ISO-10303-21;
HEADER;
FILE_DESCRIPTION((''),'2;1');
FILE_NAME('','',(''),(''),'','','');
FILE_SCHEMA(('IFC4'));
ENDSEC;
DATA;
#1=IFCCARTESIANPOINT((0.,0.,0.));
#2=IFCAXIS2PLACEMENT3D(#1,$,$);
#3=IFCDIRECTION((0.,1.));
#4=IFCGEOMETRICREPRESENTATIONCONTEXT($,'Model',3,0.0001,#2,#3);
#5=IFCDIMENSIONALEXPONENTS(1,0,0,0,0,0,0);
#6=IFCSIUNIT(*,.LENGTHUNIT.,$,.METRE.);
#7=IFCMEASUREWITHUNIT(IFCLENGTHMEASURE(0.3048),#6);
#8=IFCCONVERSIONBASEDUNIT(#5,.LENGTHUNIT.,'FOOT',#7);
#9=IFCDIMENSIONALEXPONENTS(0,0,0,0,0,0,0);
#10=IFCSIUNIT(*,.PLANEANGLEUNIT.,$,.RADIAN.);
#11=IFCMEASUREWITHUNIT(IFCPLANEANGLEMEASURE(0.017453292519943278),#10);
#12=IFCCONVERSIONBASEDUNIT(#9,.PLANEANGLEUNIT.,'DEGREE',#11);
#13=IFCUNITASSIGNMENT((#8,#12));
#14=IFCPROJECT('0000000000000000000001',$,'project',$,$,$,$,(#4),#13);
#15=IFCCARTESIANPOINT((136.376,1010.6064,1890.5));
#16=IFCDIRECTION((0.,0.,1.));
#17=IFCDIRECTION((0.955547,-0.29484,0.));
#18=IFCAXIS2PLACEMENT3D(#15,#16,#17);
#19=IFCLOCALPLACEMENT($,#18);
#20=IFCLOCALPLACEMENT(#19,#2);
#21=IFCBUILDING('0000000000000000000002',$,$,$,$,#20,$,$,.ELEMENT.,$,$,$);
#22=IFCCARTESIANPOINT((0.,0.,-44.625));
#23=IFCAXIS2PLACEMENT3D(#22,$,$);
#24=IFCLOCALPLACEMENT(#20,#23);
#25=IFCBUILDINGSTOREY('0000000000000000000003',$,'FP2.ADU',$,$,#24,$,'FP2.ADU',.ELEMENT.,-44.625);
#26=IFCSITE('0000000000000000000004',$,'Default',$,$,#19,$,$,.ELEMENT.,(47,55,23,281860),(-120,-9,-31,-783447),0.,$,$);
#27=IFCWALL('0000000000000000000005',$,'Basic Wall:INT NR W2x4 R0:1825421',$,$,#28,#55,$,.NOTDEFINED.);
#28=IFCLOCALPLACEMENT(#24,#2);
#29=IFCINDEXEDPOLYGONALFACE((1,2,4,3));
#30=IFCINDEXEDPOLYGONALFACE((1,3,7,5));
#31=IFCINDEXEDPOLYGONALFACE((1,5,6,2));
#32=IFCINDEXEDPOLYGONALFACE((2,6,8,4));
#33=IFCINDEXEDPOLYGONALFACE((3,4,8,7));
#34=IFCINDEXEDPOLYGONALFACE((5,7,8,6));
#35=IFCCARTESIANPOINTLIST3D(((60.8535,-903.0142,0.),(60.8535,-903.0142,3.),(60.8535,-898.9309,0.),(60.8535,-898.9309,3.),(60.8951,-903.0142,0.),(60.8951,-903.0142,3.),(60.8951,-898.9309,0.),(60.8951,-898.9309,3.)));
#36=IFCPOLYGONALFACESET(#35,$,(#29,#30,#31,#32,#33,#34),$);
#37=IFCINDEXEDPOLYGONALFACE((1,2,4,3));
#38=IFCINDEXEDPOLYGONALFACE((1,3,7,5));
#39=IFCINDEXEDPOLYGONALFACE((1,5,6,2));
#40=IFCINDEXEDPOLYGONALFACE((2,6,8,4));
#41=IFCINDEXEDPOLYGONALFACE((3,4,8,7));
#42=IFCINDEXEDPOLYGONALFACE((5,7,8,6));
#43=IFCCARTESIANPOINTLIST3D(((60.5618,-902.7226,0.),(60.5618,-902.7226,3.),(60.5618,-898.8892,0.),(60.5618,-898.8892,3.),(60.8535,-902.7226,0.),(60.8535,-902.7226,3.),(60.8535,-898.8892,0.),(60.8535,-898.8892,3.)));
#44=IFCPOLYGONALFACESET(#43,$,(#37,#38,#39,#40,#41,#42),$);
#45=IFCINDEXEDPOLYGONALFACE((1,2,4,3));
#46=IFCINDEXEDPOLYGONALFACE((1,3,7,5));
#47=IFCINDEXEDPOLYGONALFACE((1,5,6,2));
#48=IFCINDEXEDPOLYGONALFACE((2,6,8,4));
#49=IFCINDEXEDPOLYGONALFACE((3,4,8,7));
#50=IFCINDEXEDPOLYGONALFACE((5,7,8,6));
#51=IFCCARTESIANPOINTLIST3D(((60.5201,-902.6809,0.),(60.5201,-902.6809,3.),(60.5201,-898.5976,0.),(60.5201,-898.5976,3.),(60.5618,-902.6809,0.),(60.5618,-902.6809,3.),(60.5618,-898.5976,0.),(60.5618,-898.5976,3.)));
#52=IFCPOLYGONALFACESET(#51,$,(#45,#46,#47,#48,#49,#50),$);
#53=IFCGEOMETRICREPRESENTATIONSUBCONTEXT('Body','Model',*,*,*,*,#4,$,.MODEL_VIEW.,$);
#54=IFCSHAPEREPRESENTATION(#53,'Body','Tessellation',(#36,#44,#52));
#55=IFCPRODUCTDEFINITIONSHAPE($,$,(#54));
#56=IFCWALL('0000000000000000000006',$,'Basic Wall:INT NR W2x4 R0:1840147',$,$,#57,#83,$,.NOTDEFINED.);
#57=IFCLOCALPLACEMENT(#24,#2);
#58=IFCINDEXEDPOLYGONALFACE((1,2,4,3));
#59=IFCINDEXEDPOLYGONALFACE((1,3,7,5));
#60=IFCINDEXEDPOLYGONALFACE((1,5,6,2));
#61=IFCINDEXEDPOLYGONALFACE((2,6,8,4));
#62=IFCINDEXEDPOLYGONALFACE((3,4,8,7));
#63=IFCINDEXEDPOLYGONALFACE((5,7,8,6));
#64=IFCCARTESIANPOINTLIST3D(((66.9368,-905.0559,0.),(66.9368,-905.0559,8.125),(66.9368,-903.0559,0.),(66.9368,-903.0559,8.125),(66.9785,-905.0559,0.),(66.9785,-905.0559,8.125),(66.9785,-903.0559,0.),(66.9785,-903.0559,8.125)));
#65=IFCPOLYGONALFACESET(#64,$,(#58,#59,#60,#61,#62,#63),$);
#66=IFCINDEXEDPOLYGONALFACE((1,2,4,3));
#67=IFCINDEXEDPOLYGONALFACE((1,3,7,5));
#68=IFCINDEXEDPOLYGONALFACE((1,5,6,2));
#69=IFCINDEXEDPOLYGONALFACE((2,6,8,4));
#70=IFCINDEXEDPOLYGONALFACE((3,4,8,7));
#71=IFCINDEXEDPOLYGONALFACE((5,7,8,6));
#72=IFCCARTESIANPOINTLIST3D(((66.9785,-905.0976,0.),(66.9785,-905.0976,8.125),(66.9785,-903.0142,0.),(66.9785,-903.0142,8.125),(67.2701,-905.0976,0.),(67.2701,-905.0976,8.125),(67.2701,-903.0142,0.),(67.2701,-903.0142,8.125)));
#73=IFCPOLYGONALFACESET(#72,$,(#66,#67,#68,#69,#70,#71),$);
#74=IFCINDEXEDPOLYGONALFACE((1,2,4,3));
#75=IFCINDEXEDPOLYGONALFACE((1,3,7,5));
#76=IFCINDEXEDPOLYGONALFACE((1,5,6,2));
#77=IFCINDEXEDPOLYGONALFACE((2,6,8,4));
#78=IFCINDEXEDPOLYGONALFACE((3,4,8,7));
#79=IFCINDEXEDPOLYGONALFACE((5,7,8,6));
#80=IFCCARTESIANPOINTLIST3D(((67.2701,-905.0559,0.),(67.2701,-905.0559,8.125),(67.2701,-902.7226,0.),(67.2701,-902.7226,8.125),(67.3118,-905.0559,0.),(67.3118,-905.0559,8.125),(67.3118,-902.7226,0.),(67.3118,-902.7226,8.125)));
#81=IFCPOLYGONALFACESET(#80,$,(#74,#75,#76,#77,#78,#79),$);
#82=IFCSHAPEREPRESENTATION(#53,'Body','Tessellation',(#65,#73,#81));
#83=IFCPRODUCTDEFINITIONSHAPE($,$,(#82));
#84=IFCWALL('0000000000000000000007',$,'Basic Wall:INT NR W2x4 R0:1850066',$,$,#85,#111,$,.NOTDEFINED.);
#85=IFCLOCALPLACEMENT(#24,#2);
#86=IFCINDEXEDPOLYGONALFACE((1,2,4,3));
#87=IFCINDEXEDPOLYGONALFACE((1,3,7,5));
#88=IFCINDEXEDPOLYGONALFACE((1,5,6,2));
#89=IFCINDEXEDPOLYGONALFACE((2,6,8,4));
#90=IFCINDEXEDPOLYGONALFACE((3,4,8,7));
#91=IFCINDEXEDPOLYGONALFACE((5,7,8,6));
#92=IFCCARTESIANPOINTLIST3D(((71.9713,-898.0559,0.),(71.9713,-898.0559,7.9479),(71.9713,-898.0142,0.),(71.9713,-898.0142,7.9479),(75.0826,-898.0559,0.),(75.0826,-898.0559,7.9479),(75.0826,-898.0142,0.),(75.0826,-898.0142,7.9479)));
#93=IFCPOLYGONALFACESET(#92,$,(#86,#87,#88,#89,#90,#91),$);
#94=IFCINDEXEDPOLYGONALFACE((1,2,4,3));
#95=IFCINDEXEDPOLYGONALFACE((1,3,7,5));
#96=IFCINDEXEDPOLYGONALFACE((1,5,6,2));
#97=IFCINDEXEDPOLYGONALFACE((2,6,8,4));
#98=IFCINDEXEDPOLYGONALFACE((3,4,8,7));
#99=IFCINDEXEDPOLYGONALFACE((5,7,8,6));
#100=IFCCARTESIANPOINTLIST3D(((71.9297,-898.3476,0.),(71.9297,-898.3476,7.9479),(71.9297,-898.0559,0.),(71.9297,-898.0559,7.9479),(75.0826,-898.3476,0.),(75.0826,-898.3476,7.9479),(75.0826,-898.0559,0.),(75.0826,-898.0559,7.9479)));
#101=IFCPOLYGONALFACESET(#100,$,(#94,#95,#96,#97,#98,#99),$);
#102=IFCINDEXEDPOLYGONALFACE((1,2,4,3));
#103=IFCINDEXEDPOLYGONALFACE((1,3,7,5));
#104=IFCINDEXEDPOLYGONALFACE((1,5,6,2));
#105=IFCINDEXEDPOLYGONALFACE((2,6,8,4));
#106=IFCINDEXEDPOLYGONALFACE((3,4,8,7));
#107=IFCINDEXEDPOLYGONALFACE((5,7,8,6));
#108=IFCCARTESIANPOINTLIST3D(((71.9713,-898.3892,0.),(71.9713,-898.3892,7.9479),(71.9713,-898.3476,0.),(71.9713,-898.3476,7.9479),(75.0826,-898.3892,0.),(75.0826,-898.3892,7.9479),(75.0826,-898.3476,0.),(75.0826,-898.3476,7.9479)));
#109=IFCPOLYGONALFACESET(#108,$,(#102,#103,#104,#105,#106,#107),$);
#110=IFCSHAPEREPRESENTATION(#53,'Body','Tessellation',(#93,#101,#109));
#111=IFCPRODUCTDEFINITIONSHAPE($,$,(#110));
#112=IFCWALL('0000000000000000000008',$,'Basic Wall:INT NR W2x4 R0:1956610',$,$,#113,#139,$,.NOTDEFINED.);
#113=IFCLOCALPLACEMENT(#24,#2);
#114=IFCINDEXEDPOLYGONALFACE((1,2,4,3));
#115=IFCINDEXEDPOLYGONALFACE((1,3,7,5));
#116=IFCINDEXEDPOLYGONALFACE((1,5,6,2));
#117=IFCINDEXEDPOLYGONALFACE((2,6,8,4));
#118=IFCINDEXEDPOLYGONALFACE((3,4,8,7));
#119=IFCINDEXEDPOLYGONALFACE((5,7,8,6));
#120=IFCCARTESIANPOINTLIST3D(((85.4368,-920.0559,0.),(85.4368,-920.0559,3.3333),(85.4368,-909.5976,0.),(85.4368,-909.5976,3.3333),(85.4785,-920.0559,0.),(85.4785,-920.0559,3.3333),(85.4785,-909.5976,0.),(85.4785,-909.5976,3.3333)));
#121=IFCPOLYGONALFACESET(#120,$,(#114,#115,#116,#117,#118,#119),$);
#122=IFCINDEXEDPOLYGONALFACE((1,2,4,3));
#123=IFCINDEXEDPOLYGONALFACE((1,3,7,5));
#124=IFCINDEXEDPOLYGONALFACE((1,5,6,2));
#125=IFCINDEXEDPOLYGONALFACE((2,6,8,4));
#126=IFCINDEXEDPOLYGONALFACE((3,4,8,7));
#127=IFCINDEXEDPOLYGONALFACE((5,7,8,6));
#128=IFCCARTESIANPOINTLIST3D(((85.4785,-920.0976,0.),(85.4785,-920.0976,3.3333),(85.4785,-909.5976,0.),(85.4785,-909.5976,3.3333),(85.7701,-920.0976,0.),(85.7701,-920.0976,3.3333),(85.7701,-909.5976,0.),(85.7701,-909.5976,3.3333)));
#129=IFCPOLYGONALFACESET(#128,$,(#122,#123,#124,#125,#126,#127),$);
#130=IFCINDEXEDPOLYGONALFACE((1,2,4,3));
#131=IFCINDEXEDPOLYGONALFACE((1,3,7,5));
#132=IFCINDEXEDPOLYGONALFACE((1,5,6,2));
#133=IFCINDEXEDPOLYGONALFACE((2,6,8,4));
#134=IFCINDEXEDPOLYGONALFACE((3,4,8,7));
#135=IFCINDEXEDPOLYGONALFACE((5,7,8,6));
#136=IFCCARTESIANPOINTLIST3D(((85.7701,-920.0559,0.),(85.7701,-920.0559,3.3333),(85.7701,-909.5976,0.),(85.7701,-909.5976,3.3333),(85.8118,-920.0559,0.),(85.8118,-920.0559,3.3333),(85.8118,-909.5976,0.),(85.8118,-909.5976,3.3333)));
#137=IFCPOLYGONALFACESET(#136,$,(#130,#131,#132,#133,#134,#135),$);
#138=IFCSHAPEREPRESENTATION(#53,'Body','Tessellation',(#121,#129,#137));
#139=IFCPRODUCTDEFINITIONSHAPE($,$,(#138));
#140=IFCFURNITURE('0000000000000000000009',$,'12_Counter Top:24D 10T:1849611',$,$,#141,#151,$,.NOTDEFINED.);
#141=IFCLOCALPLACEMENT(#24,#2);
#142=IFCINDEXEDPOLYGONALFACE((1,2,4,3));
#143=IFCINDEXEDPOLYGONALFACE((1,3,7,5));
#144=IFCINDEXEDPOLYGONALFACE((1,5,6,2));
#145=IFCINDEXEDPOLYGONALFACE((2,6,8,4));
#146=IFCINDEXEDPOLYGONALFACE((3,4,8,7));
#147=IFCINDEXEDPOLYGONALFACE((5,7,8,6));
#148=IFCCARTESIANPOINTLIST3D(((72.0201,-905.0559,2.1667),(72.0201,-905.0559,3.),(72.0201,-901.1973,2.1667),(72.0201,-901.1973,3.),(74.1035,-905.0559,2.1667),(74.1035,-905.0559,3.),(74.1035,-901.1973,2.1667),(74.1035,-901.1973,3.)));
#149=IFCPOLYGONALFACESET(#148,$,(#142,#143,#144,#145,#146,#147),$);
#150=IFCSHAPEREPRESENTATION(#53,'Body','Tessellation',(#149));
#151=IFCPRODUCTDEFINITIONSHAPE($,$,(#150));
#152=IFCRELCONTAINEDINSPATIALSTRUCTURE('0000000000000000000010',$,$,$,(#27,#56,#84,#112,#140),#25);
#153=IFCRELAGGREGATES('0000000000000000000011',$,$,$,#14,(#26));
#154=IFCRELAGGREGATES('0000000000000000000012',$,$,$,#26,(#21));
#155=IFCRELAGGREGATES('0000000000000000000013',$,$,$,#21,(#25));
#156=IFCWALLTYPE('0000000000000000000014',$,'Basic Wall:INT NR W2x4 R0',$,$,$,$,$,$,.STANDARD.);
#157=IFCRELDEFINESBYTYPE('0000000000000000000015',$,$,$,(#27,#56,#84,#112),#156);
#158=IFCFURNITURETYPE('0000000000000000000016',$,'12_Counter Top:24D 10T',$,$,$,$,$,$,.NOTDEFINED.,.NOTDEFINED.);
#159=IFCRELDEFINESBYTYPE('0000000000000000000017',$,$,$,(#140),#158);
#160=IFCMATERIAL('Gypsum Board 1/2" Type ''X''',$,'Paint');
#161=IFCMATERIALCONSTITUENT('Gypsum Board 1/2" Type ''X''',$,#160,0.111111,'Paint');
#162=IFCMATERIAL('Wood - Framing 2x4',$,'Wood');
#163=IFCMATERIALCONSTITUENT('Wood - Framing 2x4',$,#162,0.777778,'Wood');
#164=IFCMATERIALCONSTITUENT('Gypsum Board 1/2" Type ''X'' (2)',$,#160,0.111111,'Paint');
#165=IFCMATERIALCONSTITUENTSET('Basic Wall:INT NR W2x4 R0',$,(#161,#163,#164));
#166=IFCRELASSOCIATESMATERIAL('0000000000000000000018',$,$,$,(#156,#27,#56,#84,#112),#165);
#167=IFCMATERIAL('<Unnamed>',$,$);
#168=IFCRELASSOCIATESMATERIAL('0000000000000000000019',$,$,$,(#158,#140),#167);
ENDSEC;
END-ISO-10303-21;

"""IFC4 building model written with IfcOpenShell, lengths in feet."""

from ifc_helpers import new_model, entity, si_unit, converted_unit, direction, frame, origin, place, context, subcontext, project, spatial, indexed_curve, outline, extrude, source, transform, mapped, material, constituent, constituent_set, type_object, type_shapes, element, save


model = new_model("IFC4")

# Units and contexts
model_context = context("Model", 3, precision=0.0001, world=origin(), true_north=direction((0.0, 1.0)))
body_context = subcontext(model_context, "Body", "Model", "MODEL_VIEW")
ifc_project = project(units=[converted_unit("LENGTHUNIT", "FOOT", entity("IfcLengthMeasure", 0.3048), si_unit("LENGTHUNIT", "METRE"), dimensions=[1, 0, 0, 0, 0, 0, 0]), converted_unit("PLANEANGLEUNIT", "DEGREE", entity("IfcPlaneAngleMeasure", 0.017453292519943278), si_unit("PLANEANGLEUNIT", "RADIAN"), dimensions=[0, 0, 0, 0, 0, 0, 0])], contexts=[model_context])

# Site, building, storey
site_placement = place(None, frame((136.376, 1010.6064, 1890.5), z_axis=(0.0, 0.0, 1.0), x_axis=(0.955547, -0.29484, 0.0)))
site = spatial("IfcSite", under=ifc_project, at=site_placement, Name="Default", CompositionType="ELEMENT", RefLatitude=(47, 55, 23, 281860), RefLongitude=(-120, -9, -31, -783447), RefElevation=0.0)
building_placement = place(site_placement, origin())
building = spatial("IfcBuilding", under=site, at=building_placement, CompositionType="ELEMENT")
storey_placement = place(building_placement, frame((0.0, 0.0, -44.625)))
storey = spatial("IfcBuildingStorey", under=building, at=storey_placement, Name="FP2.ADU", LongName="FP2.ADU", CompositionType="ELEMENT", Elevation=-44.625)

# Shared definitions
ifc_material_1 = material(Name="Gypsum Board 1/2\" Type 'X'", Category="Paint")

# Shared definitions
ifc_constituent_1 = constituent(ifc_material_1, Name="Gypsum Board 1/2\" Type 'X'", Category="Paint", fraction=0.111111)
ifc_material_2 = material(Name="Wood - Framing 2x4", Category="Wood")
ifc_constituent_2 = constituent(ifc_material_2, Name="Wood - Framing 2x4", Category="Wood", fraction=0.777778)
ifc_constituent_3 = constituent(ifc_material_1, Name="Gypsum Board 1/2\" Type 'X' (2)", Category="Paint", fraction=0.111111)
ifc_constituent_set_1 = constituent_set(constituents=[ifc_constituent_1, ifc_constituent_2, ifc_constituent_3], Name="Basic Wall:INT NR W2x4 R0")
wall_type_1 = type_object("IfcWallType", Name="Basic Wall:INT NR W2x4 R0", PredefinedType="STANDARD", material=ifc_constituent_set_1)

# Walls
wall_1_placement = place(storey_placement, frame((60.7076, -898.9309, 0.0), z_axis=(0.0, 0.0, 1.0), x_axis=(0.0, -1.0, 0.0)))
element("IfcWall", 1, at=wall_1_placement, inside=storey, type_object=wall_type_1, material=ifc_constituent_set_1, Name="Basic Wall:INT NR W2x4 R0:1825421", PredefinedType="NOTDEFINED", context=body_context, shape_type="SweptSolid", body=[
    extrude(outline(indexed_curve([(-0.0208, -2.0417), (0.0208, -2.0417), (0.0208, 2.0417), (-0.0208, 2.0417), (-0.0208, -2.0417)], self_intersect=False)), frame((2.0417, 0.1667, 0.0), z_axis=(0.0, 0.0, 1.0), x_axis=(0.0, -1.0, 0.0)), (0.0, 0.0, 1.0), 3.0),
    extrude(outline(indexed_curve([(-1.9167, -0.1458), (1.9167, -0.1458), (1.9167, 0.1458), (-1.9167, 0.1458), (-1.9167, -0.1458)], self_intersect=False)), frame((1.875, 0.0, 0.0)), (0.0, 0.0, 1.0), 3.0),
    extrude(outline(indexed_curve([(-0.0208, -2.0417), (0.0208, -2.0417), (0.0208, 2.0417), (-0.0208, 2.0417), (-0.0208, -2.0417)], self_intersect=False)), frame((1.7083, -0.1667, 0.0), z_axis=(0.0, 0.0, 1.0), x_axis=(0.0, 1.0, 0.0)), (0.0, 0.0, 1.0), 3.0),
])
wall_2_placement = place(storey_placement, frame((67.1243, -905.0559, 0.0), z_axis=(0.0, 0.0, 1.0), x_axis=(0.0, 1.0, 0.0)))
element("IfcWall", 2, at=wall_2_placement, inside=storey, type_object=wall_type_1, material=ifc_constituent_set_1, Name="Basic Wall:INT NR W2x4 R0:1840147", PredefinedType="NOTDEFINED", context=body_context, shape_type="SweptSolid", body=[
    extrude(outline(indexed_curve([(-0.0208, -1.0), (0.0208, -1.0), (0.0208, 1.0), (-0.0208, 1.0), (-0.0208, -1.0)], self_intersect=False)), frame((1.0, 0.1667, 0.0), z_axis=(0.0, 0.0, 1.0), x_axis=(0.0, -1.0, 0.0)), (0.0, 0.0, 1.0), 8.125),
    extrude(outline(indexed_curve([(-1.0417, -0.1458), (1.0417, -0.1458), (1.0417, 0.1458), (-1.0417, 0.1458), (-1.0417, -0.1458)], self_intersect=False)), frame((1.0, 0.0, 0.0)), (0.0, 0.0, 1.0), 8.125),
    extrude(outline(indexed_curve([(-0.0208, -1.1667), (0.0208, -1.1667), (0.0208, 1.1667), (-0.0208, 1.1667), (-0.0208, -1.1667)], self_intersect=False)), frame((1.1667, -0.1667, 0.0), z_axis=(0.0, 0.0, 1.0), x_axis=(0.0, 1.0, 0.0)), (0.0, 0.0, 1.0), 8.125),
])
wall_3_placement = place(storey_placement, frame((71.9713, -898.2017, 0.0)))
element("IfcWall", 3, at=wall_3_placement, inside=storey, type_object=wall_type_1, material=ifc_constituent_set_1, Name="Basic Wall:INT NR W2x4 R0:1850066", PredefinedType="NOTDEFINED", context=body_context, shape_type="SweptSolid", body=[
    extrude(outline(indexed_curve([(-0.0208, -1.5557), (0.0208, -1.5557), (0.0208, 1.5557), (-0.0208, 1.5557), (-0.0208, -1.5557)], self_intersect=False)), frame((1.5557, 0.1667, 0.0), z_axis=(0.0, 0.0, 1.0), x_axis=(0.0, -1.0, 0.0)), (0.0, 0.0, 1.0), 7.9479),
    extrude(outline(indexed_curve([(-1.5765, -0.1458), (1.5765, -0.1458), (1.5765, 0.1458), (-1.5765, 0.1458), (-1.5765, -0.1458)], self_intersect=False)), frame((1.5348, 0.0, 0.0), z_axis=(0.0, 0.0, 1.0), x_axis=(-1.0, 0.0, 0.0)), (0.0, 0.0, 1.0), 7.9479),
    extrude(outline(indexed_curve([(-0.0208, -1.5557), (0.0208, -1.5557), (0.0208, 1.5557), (-0.0208, 1.5557), (-0.0208, -1.5557)], self_intersect=False)), frame((1.5557, -0.1667, 0.0), z_axis=(0.0, 0.0, 1.0), x_axis=(0.0, 1.0, 0.0)), (0.0, 0.0, 1.0), 7.9479),
])
wall_4_placement = place(storey_placement, frame((85.6243, -909.5976, 0.0), z_axis=(0.0, 0.0, 1.0), x_axis=(0.0, -1.0, 0.0)))
element("IfcWall", 4, at=wall_4_placement, inside=storey, type_object=wall_type_1, material=ifc_constituent_set_1, Name="Basic Wall:INT NR W2x4 R0:1956610", PredefinedType="NOTDEFINED", context=body_context, shape_type="SweptSolid", body=[
    extrude(outline(indexed_curve([(-0.0208, -5.2292), (0.0208, -5.2292), (0.0208, 5.2292), (-0.0208, 5.2292), (-0.0208, -5.2292)], self_intersect=False)), frame((5.2292, -0.1667, 0.0), z_axis=(0.0, 0.0, 1.0), x_axis=(0.0, 1.0, 0.0)), (0.0, 0.0, 1.0), 3.3333),
    extrude(outline(indexed_curve([(-5.25, -0.1458), (5.25, -0.1458), (5.25, 0.1458), (-5.25, 0.1458), (-5.25, -0.1458)], self_intersect=False)), frame((5.25, 0.0, 0.0)), (0.0, 0.0, 1.0), 3.3333),
    extrude(outline(indexed_curve([(-0.0208, -5.2292), (0.0208, -5.2292), (0.0208, 5.2292), (-0.0208, 5.2292), (-0.0208, -5.2292)], self_intersect=False)), frame((5.2292, 0.1667, 0.0), z_axis=(0.0, 0.0, 1.0), x_axis=(0.0, -1.0, 0.0)), (0.0, 0.0, 1.0), 3.3333),
])

# Furniture
ifc_material_3 = material(Name="<Unnamed>")
furniture_type_1 = type_object("IfcFurnitureType", Name="12_Counter Top:24D 10T", AssemblyPlace="NOTDEFINED", PredefinedType="NOTDEFINED", material=ifc_material_3)
shared_shape_1 = source(origin(), body_context, "Body", "SweptSolid", [
    extrude(outline(indexed_curve([(-1.0417, -1.9293), (1.0417, -1.9293), (1.0417, 1.9293), (-1.0417, 1.9293), (-1.0417, -1.9293)], self_intersect=False)), frame((-2.0092, 1.0417, 2.1667), z_axis=(0.0, 0.0, 1.0), x_axis=(0.0, 1.0, 0.0)), (0.0, 0.0, 1.0), 0.8333),
])
type_shapes(furniture_type_1, [shared_shape_1])
furniture_1_placement = place(storey_placement, frame((72.0201, -905.1358, 0.0), z_axis=(0.0, 0.0, 1.0), x_axis=(0.0, -1.0, 0.0)))
element("IfcFurniture", 5, at=furniture_1_placement, inside=storey, type_object=furniture_type_1, material=ifc_material_3, Name="12_Counter Top:24D 10T:1849611", PredefinedType="NOTDEFINED", context=body_context, shape_type="MappedRepresentation", body=[
    mapped(shared_shape_1, transform((0.0, 0.0, 0.0), scale=1.0)),
])

save(model, "model.ifc")
